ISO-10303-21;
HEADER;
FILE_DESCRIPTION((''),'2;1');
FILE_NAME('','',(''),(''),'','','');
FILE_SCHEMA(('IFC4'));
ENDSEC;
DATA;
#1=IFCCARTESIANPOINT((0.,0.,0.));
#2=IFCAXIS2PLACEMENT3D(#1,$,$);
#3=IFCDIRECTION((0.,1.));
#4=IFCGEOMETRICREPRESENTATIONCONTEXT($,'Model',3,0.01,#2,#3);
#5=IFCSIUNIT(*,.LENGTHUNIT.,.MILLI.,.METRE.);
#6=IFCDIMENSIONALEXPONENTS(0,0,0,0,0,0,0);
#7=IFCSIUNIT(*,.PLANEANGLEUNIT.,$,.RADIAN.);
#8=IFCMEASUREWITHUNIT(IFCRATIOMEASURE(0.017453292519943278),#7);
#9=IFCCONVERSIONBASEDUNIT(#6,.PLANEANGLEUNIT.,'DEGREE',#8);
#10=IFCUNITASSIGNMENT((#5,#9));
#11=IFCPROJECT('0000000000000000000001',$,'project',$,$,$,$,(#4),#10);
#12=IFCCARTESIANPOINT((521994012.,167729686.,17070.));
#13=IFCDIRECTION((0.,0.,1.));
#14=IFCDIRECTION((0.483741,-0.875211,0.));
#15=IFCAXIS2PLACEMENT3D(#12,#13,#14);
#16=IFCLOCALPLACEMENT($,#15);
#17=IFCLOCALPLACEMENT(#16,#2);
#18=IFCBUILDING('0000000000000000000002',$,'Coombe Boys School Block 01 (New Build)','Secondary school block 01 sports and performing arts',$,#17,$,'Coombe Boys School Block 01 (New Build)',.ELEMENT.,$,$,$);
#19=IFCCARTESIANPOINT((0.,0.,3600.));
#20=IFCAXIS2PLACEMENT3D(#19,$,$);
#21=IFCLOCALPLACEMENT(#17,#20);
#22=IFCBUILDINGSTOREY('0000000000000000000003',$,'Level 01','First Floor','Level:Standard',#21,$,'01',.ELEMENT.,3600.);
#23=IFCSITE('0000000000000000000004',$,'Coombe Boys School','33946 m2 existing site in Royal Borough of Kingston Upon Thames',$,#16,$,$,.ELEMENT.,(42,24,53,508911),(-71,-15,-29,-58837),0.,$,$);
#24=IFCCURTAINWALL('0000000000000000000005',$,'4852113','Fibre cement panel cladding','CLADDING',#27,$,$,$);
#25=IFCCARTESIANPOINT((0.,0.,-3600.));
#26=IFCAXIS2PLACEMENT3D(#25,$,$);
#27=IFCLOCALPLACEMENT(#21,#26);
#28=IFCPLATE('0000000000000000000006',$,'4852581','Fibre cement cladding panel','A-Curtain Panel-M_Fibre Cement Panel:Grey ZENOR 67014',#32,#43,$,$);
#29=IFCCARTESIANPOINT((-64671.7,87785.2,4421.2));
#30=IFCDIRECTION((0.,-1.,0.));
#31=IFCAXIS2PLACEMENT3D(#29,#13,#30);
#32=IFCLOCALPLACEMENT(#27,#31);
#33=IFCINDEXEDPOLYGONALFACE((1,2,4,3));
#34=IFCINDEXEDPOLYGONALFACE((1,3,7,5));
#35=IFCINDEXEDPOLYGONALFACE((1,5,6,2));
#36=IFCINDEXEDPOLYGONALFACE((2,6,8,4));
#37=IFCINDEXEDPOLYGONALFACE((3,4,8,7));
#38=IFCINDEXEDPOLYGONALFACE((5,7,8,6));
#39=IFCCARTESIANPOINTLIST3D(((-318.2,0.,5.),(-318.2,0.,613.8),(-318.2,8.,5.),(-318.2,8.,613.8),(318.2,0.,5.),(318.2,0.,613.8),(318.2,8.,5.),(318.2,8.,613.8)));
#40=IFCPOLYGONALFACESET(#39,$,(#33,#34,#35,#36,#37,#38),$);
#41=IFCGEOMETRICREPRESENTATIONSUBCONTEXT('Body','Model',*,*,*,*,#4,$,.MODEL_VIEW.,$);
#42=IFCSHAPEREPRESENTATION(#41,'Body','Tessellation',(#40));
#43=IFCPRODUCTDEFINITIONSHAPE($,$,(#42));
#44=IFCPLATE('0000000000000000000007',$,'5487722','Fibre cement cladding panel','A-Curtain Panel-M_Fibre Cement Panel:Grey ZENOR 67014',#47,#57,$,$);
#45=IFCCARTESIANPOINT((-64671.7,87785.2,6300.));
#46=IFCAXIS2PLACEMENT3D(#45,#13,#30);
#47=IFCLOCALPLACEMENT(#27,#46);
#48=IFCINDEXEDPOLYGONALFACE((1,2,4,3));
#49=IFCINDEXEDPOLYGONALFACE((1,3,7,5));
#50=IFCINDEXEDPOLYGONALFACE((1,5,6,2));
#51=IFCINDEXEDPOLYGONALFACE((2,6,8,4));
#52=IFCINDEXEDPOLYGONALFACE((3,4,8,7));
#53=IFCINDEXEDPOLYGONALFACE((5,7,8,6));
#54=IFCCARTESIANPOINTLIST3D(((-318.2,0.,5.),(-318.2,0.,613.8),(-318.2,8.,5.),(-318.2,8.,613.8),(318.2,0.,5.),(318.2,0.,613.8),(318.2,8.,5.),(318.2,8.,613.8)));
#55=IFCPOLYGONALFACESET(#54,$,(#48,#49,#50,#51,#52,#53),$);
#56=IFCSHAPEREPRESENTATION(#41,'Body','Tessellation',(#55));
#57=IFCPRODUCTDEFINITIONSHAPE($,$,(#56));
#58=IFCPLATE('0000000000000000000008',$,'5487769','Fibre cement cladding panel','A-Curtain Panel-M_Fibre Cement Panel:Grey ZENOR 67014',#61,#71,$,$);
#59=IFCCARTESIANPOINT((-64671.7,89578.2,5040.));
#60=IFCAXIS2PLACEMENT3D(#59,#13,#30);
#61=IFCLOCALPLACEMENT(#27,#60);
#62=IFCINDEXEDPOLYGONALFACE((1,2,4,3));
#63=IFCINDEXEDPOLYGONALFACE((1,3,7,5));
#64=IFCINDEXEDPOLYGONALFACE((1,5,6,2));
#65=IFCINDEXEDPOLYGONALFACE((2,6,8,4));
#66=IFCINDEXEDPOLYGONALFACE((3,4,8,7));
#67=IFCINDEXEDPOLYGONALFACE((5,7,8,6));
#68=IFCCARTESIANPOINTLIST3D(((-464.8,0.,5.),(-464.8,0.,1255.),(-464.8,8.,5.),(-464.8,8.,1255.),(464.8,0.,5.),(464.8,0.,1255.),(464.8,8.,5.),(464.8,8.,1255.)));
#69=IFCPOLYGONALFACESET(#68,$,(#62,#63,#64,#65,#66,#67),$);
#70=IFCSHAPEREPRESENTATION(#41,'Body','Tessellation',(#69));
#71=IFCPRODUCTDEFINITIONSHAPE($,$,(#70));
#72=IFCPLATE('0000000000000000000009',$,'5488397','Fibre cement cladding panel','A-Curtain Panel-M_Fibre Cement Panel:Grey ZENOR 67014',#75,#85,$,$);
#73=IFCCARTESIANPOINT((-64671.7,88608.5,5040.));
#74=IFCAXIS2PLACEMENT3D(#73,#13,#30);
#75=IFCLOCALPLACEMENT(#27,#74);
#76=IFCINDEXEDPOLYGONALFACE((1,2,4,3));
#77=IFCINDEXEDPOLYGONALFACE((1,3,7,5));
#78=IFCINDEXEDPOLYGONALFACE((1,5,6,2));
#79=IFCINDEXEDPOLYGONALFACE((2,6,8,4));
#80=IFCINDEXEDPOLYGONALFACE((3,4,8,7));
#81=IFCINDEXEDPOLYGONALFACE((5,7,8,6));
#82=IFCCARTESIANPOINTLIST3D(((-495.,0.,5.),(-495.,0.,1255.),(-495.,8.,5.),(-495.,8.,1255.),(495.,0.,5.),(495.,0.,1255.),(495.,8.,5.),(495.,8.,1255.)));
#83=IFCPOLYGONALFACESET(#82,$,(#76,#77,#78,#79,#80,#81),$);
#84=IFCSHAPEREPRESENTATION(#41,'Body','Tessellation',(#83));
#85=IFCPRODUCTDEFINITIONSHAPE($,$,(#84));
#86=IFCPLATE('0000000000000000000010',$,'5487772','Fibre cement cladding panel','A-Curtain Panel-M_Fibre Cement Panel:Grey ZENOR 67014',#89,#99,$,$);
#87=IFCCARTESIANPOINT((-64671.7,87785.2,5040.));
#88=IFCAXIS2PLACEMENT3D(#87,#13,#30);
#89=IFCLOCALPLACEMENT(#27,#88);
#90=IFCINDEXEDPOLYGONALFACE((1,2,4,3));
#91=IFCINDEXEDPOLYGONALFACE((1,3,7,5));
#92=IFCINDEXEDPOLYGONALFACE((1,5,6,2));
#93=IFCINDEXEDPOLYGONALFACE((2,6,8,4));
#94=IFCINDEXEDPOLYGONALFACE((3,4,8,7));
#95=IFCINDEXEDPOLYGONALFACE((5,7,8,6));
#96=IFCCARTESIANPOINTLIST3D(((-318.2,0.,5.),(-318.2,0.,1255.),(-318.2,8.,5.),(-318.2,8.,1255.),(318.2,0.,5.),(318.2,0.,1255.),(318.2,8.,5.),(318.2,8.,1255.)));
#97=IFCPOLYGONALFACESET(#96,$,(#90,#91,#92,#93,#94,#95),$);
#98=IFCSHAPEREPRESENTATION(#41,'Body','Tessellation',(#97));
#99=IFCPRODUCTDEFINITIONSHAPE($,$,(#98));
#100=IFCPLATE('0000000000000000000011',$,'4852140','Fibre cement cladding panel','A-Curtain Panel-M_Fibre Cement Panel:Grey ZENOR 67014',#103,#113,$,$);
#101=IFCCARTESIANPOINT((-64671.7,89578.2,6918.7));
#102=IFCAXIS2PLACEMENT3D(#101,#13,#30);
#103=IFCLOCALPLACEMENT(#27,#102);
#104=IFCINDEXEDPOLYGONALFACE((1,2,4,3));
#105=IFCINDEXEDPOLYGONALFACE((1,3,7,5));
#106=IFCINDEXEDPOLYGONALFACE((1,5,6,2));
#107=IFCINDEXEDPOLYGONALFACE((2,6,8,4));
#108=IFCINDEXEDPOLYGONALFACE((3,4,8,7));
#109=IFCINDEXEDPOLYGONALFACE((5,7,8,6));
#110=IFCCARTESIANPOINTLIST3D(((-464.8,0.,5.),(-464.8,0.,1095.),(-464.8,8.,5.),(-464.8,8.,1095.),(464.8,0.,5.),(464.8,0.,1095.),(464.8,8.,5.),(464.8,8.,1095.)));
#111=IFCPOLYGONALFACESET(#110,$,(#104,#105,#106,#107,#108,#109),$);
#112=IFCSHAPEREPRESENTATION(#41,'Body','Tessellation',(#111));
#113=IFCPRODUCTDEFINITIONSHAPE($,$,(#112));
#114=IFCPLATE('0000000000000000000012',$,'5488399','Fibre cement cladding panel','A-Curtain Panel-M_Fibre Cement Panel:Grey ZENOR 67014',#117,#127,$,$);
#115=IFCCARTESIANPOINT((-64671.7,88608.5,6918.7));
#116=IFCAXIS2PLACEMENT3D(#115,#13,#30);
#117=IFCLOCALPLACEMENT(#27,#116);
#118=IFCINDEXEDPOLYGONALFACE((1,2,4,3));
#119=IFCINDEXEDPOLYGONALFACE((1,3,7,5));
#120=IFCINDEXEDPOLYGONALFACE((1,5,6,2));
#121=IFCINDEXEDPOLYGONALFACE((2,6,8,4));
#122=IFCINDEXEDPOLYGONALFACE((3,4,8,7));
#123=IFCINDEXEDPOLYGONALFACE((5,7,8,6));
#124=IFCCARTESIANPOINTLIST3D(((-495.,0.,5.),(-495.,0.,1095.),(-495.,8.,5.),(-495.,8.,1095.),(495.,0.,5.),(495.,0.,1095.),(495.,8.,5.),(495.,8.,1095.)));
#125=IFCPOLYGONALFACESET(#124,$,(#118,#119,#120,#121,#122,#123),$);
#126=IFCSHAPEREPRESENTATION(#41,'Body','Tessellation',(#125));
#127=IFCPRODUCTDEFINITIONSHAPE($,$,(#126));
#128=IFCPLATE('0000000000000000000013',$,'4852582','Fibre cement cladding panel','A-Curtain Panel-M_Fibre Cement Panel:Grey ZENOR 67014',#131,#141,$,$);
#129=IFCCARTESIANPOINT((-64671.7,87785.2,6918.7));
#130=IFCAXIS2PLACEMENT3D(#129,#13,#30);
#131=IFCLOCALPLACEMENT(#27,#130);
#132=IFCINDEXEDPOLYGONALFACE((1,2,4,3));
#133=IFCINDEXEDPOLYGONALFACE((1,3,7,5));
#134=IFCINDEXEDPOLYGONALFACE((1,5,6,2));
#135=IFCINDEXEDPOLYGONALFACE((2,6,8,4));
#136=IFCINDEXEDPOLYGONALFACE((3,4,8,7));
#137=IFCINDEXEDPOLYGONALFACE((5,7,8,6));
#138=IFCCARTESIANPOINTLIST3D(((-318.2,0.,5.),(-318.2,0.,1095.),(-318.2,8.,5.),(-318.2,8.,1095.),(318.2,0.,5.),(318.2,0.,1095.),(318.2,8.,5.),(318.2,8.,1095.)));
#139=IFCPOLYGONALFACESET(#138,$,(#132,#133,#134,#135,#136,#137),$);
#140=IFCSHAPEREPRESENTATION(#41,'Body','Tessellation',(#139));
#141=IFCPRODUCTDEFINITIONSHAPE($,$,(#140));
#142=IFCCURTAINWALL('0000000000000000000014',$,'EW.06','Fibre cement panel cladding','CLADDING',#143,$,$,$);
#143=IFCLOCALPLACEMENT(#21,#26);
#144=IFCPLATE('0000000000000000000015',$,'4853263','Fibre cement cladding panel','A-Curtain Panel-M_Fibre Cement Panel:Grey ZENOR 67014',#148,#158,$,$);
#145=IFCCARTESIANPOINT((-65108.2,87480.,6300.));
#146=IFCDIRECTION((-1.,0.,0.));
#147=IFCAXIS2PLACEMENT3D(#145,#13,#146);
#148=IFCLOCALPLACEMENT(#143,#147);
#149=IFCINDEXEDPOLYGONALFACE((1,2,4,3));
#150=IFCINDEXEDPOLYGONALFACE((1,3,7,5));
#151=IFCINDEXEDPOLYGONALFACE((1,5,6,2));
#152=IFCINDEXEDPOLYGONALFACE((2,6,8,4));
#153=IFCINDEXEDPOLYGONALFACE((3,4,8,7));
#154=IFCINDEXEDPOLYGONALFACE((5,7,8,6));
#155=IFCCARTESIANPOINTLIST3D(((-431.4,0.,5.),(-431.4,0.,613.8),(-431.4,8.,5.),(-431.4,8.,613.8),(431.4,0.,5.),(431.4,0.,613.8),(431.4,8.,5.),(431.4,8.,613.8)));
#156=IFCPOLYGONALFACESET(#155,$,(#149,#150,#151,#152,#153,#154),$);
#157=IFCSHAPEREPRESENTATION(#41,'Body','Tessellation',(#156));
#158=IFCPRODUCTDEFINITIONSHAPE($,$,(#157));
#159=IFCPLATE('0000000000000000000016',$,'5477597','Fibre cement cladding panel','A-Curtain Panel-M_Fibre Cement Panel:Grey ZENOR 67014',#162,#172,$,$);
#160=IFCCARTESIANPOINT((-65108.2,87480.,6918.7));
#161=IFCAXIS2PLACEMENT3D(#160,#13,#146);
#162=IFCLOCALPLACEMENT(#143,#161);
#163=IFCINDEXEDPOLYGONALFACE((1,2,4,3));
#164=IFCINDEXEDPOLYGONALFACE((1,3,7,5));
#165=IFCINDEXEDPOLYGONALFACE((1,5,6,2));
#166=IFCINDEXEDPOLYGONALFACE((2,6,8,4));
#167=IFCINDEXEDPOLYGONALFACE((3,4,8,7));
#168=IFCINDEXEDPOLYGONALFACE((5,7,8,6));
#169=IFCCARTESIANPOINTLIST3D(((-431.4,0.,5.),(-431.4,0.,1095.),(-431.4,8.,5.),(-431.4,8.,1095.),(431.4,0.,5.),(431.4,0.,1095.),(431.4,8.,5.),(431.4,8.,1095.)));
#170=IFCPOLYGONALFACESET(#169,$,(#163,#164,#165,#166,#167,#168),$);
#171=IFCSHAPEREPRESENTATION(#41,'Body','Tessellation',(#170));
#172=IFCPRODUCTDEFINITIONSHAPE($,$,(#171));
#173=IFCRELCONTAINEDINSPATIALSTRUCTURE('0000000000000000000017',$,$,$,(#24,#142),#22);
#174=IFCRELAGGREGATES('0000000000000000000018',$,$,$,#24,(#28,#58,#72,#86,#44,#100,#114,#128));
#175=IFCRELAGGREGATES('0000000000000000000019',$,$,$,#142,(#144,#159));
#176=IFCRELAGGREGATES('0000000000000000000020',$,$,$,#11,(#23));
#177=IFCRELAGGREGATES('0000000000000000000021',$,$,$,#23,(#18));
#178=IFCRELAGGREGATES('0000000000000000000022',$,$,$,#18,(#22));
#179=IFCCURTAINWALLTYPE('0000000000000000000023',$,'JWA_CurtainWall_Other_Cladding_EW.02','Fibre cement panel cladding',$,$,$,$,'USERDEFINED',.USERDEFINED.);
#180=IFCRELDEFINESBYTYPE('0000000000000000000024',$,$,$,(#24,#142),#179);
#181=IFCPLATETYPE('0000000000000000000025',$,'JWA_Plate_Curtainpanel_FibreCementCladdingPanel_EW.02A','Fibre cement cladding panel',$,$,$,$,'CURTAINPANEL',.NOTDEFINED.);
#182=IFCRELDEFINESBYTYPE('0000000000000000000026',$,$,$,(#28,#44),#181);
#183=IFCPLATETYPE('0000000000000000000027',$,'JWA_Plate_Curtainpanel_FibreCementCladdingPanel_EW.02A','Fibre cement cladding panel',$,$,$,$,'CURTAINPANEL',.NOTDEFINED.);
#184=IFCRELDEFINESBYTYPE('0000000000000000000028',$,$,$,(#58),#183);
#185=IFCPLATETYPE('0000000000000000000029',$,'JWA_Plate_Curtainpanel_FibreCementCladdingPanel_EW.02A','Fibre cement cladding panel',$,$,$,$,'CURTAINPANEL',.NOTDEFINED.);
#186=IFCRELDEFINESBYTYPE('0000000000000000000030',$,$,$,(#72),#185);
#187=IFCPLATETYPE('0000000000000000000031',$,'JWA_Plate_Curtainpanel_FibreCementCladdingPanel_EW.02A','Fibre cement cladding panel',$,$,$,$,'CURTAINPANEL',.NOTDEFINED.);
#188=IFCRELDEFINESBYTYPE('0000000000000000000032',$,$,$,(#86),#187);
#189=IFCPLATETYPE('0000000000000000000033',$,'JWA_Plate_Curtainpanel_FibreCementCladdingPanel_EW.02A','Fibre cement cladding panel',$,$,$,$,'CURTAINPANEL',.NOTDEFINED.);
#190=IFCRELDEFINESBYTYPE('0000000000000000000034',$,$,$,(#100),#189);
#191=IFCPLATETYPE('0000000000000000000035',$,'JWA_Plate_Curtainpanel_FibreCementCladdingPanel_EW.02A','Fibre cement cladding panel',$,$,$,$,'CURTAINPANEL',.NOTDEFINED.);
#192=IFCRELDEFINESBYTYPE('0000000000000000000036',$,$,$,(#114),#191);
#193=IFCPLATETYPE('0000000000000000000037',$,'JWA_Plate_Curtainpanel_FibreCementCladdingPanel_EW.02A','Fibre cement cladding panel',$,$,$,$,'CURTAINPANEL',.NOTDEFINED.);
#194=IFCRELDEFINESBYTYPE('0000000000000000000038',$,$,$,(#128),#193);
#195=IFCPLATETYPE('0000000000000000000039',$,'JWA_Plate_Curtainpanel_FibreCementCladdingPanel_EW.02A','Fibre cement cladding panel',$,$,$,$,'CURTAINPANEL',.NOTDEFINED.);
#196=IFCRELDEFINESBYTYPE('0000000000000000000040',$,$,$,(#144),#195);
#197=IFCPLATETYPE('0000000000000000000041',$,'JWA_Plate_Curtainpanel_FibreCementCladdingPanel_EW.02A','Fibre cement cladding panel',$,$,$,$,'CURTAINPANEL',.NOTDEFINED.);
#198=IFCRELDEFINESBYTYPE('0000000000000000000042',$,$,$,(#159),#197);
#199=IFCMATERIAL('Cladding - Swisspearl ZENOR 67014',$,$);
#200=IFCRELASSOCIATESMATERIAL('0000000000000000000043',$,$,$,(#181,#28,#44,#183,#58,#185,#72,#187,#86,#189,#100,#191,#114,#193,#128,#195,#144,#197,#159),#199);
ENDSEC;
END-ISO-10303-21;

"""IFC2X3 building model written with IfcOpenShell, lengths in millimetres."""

from ifc_helpers import new_model, entity, si_unit, converted_unit, direction, frame, origin, origin_2d_with_axis, place, context, subcontext, project, spatial, rectangle, extrude, source, transform, mapped, material, type_object, type_shapes, element, aggregate, save


model = new_model("IFC2X3")

# Units and contexts
model_context = context("Model", 3, precision=0.01, world=origin(), true_north=direction((0.0, 1.0)))
body_context = subcontext(model_context, "Body", "Model", "MODEL_VIEW")
ifc_project = project(units=[si_unit("LENGTHUNIT", "METRE", prefix="MILLI"), converted_unit("PLANEANGLEUNIT", "DEGREE", entity("IfcRatioMeasure", 0.017453292519943278), si_unit("PLANEANGLEUNIT", "RADIAN"), dimensions=[0, 0, 0, 0, 0, 0, 0])], contexts=[model_context])

# Site, building, storey
site_placement = place(None, frame((521994012.0, 167729686.0, 17070.0), z_axis=(0.0, 0.0, 1.0), x_axis=(0.483741, -0.875211, 0.0)))
site = spatial("IfcSite", under=ifc_project, at=site_placement, Name="Coombe Boys School", Description="33946 m2 existing site in Royal Borough of Kingston Upon Thames", CompositionType="ELEMENT", RefLatitude=(42, 24, 53, 508911), RefLongitude=(-71, -15, -29, -58837), RefElevation=0.0)
building_placement = place(site_placement, origin())
building = spatial("IfcBuilding", under=site, at=building_placement, Name="Coombe Boys School Block 01 (New Build)", Description="Secondary school block 01 sports and performing arts", LongName="Coombe Boys School Block 01 (New Build)", CompositionType="ELEMENT")
storey_placement = place(building_placement, frame((0.0, 0.0, 3600.0)))
storey = spatial("IfcBuildingStorey", under=building, at=storey_placement, Name="Level 01", Description="First Floor", ObjectType="Level:Standard", LongName="01", CompositionType="ELEMENT", Elevation=3600.0)

# Curtain walls, plates
curtain_wall_type = type_object("IfcCurtainWallType", Name="JWA_CurtainWall_Other_Cladding_EW.02", Description="Fibre cement panel cladding", ElementType="USERDEFINED", PredefinedType="USERDEFINED")
curtain_wall_1_placement = place(storey_placement, frame((0.0, 0.0, -3600.0)))
curtain_wall_1 = element("IfcCurtainWall", 1, at=curtain_wall_1_placement, inside=storey, type_object=curtain_wall_type, Name="4852113", Description="Fibre cement panel cladding", ObjectType="CLADDING")
ifc_material_1 = material(Name="Cladding - Swisspearl ZENOR 67014")
plate_type_1 = type_object("IfcPlateType", Name="JWA_Plate_Curtainpanel_FibreCementCladdingPanel_EW.02A", Description="Fibre cement cladding panel", ElementType="CURTAINPANEL", PredefinedType="NOTDEFINED", material=ifc_material_1)
shared_shape_1 = source(origin(), body_context, "Body", "SweptSolid", [
    extrude(rectangle(XDim=8.0, YDim=636.5, at=origin_2d_with_axis()), frame((0.0, 4.0, 5.0), z_axis=(0.0, 0.0, 1.0), x_axis=(0.0, 1.0, 0.0)), (0.0, 0.0, 1.0), 608.8),
])
type_shapes(plate_type_1, [shared_shape_1])
plate_1_placement = place(curtain_wall_1_placement, frame((-64671.7, 87785.2, 4421.2), z_axis=(0.0, 0.0, 1.0), x_axis=(0.0, -1.0, 0.0)))
plate_1 = element("IfcPlate", 2, at=plate_1_placement, type_object=plate_type_1, material=ifc_material_1, Name="4852581", Description="Fibre cement cladding panel", ObjectType="A-Curtain Panel-M_Fibre Cement Panel:Grey ZENOR 67014", context=body_context, shape_type="MappedRepresentation", body=[
    mapped(shared_shape_1, transform((0.0, 0.0, 0.0), scale=1.0)),
])
plate_2_placement = place(curtain_wall_1_placement, frame((-64671.7, 87785.2, 6300.0), z_axis=(0.0, 0.0, 1.0), x_axis=(0.0, -1.0, 0.0)))
plate_2 = element("IfcPlate", 3, at=plate_2_placement, type_object=plate_type_1, material=ifc_material_1, Name="5487722", Description="Fibre cement cladding panel", ObjectType="A-Curtain Panel-M_Fibre Cement Panel:Grey ZENOR 67014", context=body_context, shape_type="MappedRepresentation", body=[
    mapped(shared_shape_1, transform((0.0, 0.0, 0.0), scale=1.0)),
])
plate_type_2 = type_object("IfcPlateType", Name="JWA_Plate_Curtainpanel_FibreCementCladdingPanel_EW.02A", Description="Fibre cement cladding panel", ElementType="CURTAINPANEL", PredefinedType="NOTDEFINED", material=ifc_material_1)
shared_shape_2 = source(origin(), body_context, "Body", "SweptSolid", [
    extrude(rectangle(XDim=8.0, YDim=929.5, at=origin_2d_with_axis()), frame((0.0, 4.0, 5.0), z_axis=(0.0, 0.0, 1.0), x_axis=(0.0, 1.0, 0.0)), (0.0, 0.0, 1.0), 1250.0),
])
type_shapes(plate_type_2, [shared_shape_2])
plate_3_placement = place(curtain_wall_1_placement, frame((-64671.7, 89578.2, 5040.0), z_axis=(0.0, 0.0, 1.0), x_axis=(0.0, -1.0, 0.0)))
plate_3 = element("IfcPlate", 4, at=plate_3_placement, type_object=plate_type_2, material=ifc_material_1, Name="5487769", Description="Fibre cement cladding panel", ObjectType="A-Curtain Panel-M_Fibre Cement Panel:Grey ZENOR 67014", context=body_context, shape_type="MappedRepresentation", body=[
    mapped(shared_shape_2, transform((0.0, 0.0, 0.0), scale=1.0)),
])
plate_type_3 = type_object("IfcPlateType", Name="JWA_Plate_Curtainpanel_FibreCementCladdingPanel_EW.02A", Description="Fibre cement cladding panel", ElementType="CURTAINPANEL", PredefinedType="NOTDEFINED", material=ifc_material_1)
shared_shape_3 = source(origin(), body_context, "Body", "SweptSolid", [
    extrude(rectangle(XDim=8.0, YDim=990.0, at=origin_2d_with_axis()), frame((0.0, 4.0, 5.0), z_axis=(0.0, 0.0, 1.0), x_axis=(0.0, 1.0, 0.0)), (0.0, 0.0, 1.0), 1250.0),
])
type_shapes(plate_type_3, [shared_shape_3])
plate_4_placement = place(curtain_wall_1_placement, frame((-64671.7, 88608.5, 5040.0), z_axis=(0.0, 0.0, 1.0), x_axis=(0.0, -1.0, 0.0)))
plate_4 = element("IfcPlate", 5, at=plate_4_placement, type_object=plate_type_3, material=ifc_material_1, Name="5488397", Description="Fibre cement cladding panel", ObjectType="A-Curtain Panel-M_Fibre Cement Panel:Grey ZENOR 67014", context=body_context, shape_type="MappedRepresentation", body=[
    mapped(shared_shape_3, transform((0.0, 0.0, 0.0), scale=1.0)),
])
plate_type_4 = type_object("IfcPlateType", Name="JWA_Plate_Curtainpanel_FibreCementCladdingPanel_EW.02A", Description="Fibre cement cladding panel", ElementType="CURTAINPANEL", PredefinedType="NOTDEFINED", material=ifc_material_1)
shared_shape_4 = source(origin(), body_context, "Body", "SweptSolid", [
    extrude(rectangle(XDim=8.0, YDim=636.5, at=origin_2d_with_axis()), frame((0.0, 4.0, 5.0), z_axis=(0.0, 0.0, 1.0), x_axis=(0.0, 1.0, 0.0)), (0.0, 0.0, 1.0), 1250.0),
])
type_shapes(plate_type_4, [shared_shape_4])
plate_5_placement = place(curtain_wall_1_placement, frame((-64671.7, 87785.2, 5040.0), z_axis=(0.0, 0.0, 1.0), x_axis=(0.0, -1.0, 0.0)))
plate_5 = element("IfcPlate", 6, at=plate_5_placement, type_object=plate_type_4, material=ifc_material_1, Name="5487772", Description="Fibre cement cladding panel", ObjectType="A-Curtain Panel-M_Fibre Cement Panel:Grey ZENOR 67014", context=body_context, shape_type="MappedRepresentation", body=[
    mapped(shared_shape_4, transform((0.0, 0.0, 0.0), scale=1.0)),
])
plate_type_5 = type_object("IfcPlateType", Name="JWA_Plate_Curtainpanel_FibreCementCladdingPanel_EW.02A", Description="Fibre cement cladding panel", ElementType="CURTAINPANEL", PredefinedType="NOTDEFINED", material=ifc_material_1)
shared_shape_5 = source(origin(), body_context, "Body", "SweptSolid", [
    extrude(rectangle(XDim=8.0, YDim=929.5, at=origin_2d_with_axis()), frame((0.0, 4.0, 5.0), z_axis=(0.0, 0.0, 1.0), x_axis=(0.0, 1.0, 0.0)), (0.0, 0.0, 1.0), 1090.0),
])
type_shapes(plate_type_5, [shared_shape_5])
plate_6_placement = place(curtain_wall_1_placement, frame((-64671.7, 89578.2, 6918.7), z_axis=(0.0, 0.0, 1.0), x_axis=(0.0, -1.0, 0.0)))
plate_6 = element("IfcPlate", 7, at=plate_6_placement, type_object=plate_type_5, material=ifc_material_1, Name="4852140", Description="Fibre cement cladding panel", ObjectType="A-Curtain Panel-M_Fibre Cement Panel:Grey ZENOR 67014", context=body_context, shape_type="MappedRepresentation", body=[
    mapped(shared_shape_5, transform((0.0, 0.0, 0.0), scale=1.0)),
])
plate_type_6 = type_object("IfcPlateType", Name="JWA_Plate_Curtainpanel_FibreCementCladdingPanel_EW.02A", Description="Fibre cement cladding panel", ElementType="CURTAINPANEL", PredefinedType="NOTDEFINED", material=ifc_material_1)
shared_shape_6 = source(origin(), body_context, "Body", "SweptSolid", [
    extrude(rectangle(XDim=8.0, YDim=990.0, at=origin_2d_with_axis()), frame((0.0, 4.0, 5.0), z_axis=(0.0, 0.0, 1.0), x_axis=(0.0, 1.0, 0.0)), (0.0, 0.0, 1.0), 1090.0),
])
type_shapes(plate_type_6, [shared_shape_6])
plate_7_placement = place(curtain_wall_1_placement, frame((-64671.7, 88608.5, 6918.7), z_axis=(0.0, 0.0, 1.0), x_axis=(0.0, -1.0, 0.0)))
plate_7 = element("IfcPlate", 8, at=plate_7_placement, type_object=plate_type_6, material=ifc_material_1, Name="5488399", Description="Fibre cement cladding panel", ObjectType="A-Curtain Panel-M_Fibre Cement Panel:Grey ZENOR 67014", context=body_context, shape_type="MappedRepresentation", body=[
    mapped(shared_shape_6, transform((0.0, 0.0, 0.0), scale=1.0)),
])
plate_type_7 = type_object("IfcPlateType", Name="JWA_Plate_Curtainpanel_FibreCementCladdingPanel_EW.02A", Description="Fibre cement cladding panel", ElementType="CURTAINPANEL", PredefinedType="NOTDEFINED", material=ifc_material_1)
shared_shape_7 = source(origin(), body_context, "Body", "SweptSolid", [
    extrude(rectangle(XDim=8.0, YDim=636.5, at=origin_2d_with_axis()), frame((0.0, 4.0, 5.0), z_axis=(0.0, 0.0, 1.0), x_axis=(0.0, 1.0, 0.0)), (0.0, 0.0, 1.0), 1090.0),
])
type_shapes(plate_type_7, [shared_shape_7])
plate_8_placement = place(curtain_wall_1_placement, frame((-64671.7, 87785.2, 6918.7), z_axis=(0.0, 0.0, 1.0), x_axis=(0.0, -1.0, 0.0)))
plate_8 = element("IfcPlate", 9, at=plate_8_placement, type_object=plate_type_7, material=ifc_material_1, Name="4852582", Description="Fibre cement cladding panel", ObjectType="A-Curtain Panel-M_Fibre Cement Panel:Grey ZENOR 67014", context=body_context, shape_type="MappedRepresentation", body=[
    mapped(shared_shape_7, transform((0.0, 0.0, 0.0), scale=1.0)),
])
aggregate(curtain_wall_1, [plate_1, plate_3, plate_4, plate_5, plate_2, plate_6, plate_7, plate_8])
curtain_wall_2_placement = place(storey_placement, frame((0.0, 0.0, -3600.0)))
curtain_wall_2 = element("IfcCurtainWall", 10, at=curtain_wall_2_placement, inside=storey, type_object=curtain_wall_type, Name="EW.06", Description="Fibre cement panel cladding", ObjectType="CLADDING")
plate_type_8 = type_object("IfcPlateType", Name="JWA_Plate_Curtainpanel_FibreCementCladdingPanel_EW.02A", Description="Fibre cement cladding panel", ElementType="CURTAINPANEL", PredefinedType="NOTDEFINED", material=ifc_material_1)
shared_shape_8 = source(origin(), body_context, "Body", "SweptSolid", [
    extrude(rectangle(XDim=8.0, YDim=862.9, at=origin_2d_with_axis()), frame((0.0, 4.0, 5.0), z_axis=(0.0, 0.0, 1.0), x_axis=(0.0, 1.0, 0.0)), (0.0, 0.0, 1.0), 608.8),
])
type_shapes(plate_type_8, [shared_shape_8])
plate_9_placement = place(curtain_wall_2_placement, frame((-65108.2, 87480.0, 6300.0), z_axis=(0.0, 0.0, 1.0), x_axis=(-1.0, 0.0, 0.0)))
plate_9 = element("IfcPlate", 11, at=plate_9_placement, type_object=plate_type_8, material=ifc_material_1, Name="4853263", Description="Fibre cement cladding panel", ObjectType="A-Curtain Panel-M_Fibre Cement Panel:Grey ZENOR 67014", context=body_context, shape_type="MappedRepresentation", body=[
    mapped(shared_shape_8, transform((0.0, 0.0, 0.0), scale=1.0)),
])
plate_type_9 = type_object("IfcPlateType", Name="JWA_Plate_Curtainpanel_FibreCementCladdingPanel_EW.02A", Description="Fibre cement cladding panel", ElementType="CURTAINPANEL", PredefinedType="NOTDEFINED", material=ifc_material_1)
shared_shape_9 = source(origin(), body_context, "Body", "SweptSolid", [
    extrude(rectangle(XDim=8.0, YDim=862.9, at=origin_2d_with_axis()), frame((0.0, 4.0, 5.0), z_axis=(0.0, 0.0, 1.0), x_axis=(0.0, 1.0, 0.0)), (0.0, 0.0, 1.0), 1090.0),
])
type_shapes(plate_type_9, [shared_shape_9])
plate_10_placement = place(curtain_wall_2_placement, frame((-65108.2, 87480.0, 6918.7), z_axis=(0.0, 0.0, 1.0), x_axis=(-1.0, 0.0, 0.0)))
plate_10 = element("IfcPlate", 12, at=plate_10_placement, type_object=plate_type_9, material=ifc_material_1, Name="5477597", Description="Fibre cement cladding panel", ObjectType="A-Curtain Panel-M_Fibre Cement Panel:Grey ZENOR 67014", context=body_context, shape_type="MappedRepresentation", body=[
    mapped(shared_shape_9, transform((0.0, 0.0, 0.0), scale=1.0)),
])
aggregate(curtain_wall_2, [plate_9, plate_10])

save(model, "model.ifc")
